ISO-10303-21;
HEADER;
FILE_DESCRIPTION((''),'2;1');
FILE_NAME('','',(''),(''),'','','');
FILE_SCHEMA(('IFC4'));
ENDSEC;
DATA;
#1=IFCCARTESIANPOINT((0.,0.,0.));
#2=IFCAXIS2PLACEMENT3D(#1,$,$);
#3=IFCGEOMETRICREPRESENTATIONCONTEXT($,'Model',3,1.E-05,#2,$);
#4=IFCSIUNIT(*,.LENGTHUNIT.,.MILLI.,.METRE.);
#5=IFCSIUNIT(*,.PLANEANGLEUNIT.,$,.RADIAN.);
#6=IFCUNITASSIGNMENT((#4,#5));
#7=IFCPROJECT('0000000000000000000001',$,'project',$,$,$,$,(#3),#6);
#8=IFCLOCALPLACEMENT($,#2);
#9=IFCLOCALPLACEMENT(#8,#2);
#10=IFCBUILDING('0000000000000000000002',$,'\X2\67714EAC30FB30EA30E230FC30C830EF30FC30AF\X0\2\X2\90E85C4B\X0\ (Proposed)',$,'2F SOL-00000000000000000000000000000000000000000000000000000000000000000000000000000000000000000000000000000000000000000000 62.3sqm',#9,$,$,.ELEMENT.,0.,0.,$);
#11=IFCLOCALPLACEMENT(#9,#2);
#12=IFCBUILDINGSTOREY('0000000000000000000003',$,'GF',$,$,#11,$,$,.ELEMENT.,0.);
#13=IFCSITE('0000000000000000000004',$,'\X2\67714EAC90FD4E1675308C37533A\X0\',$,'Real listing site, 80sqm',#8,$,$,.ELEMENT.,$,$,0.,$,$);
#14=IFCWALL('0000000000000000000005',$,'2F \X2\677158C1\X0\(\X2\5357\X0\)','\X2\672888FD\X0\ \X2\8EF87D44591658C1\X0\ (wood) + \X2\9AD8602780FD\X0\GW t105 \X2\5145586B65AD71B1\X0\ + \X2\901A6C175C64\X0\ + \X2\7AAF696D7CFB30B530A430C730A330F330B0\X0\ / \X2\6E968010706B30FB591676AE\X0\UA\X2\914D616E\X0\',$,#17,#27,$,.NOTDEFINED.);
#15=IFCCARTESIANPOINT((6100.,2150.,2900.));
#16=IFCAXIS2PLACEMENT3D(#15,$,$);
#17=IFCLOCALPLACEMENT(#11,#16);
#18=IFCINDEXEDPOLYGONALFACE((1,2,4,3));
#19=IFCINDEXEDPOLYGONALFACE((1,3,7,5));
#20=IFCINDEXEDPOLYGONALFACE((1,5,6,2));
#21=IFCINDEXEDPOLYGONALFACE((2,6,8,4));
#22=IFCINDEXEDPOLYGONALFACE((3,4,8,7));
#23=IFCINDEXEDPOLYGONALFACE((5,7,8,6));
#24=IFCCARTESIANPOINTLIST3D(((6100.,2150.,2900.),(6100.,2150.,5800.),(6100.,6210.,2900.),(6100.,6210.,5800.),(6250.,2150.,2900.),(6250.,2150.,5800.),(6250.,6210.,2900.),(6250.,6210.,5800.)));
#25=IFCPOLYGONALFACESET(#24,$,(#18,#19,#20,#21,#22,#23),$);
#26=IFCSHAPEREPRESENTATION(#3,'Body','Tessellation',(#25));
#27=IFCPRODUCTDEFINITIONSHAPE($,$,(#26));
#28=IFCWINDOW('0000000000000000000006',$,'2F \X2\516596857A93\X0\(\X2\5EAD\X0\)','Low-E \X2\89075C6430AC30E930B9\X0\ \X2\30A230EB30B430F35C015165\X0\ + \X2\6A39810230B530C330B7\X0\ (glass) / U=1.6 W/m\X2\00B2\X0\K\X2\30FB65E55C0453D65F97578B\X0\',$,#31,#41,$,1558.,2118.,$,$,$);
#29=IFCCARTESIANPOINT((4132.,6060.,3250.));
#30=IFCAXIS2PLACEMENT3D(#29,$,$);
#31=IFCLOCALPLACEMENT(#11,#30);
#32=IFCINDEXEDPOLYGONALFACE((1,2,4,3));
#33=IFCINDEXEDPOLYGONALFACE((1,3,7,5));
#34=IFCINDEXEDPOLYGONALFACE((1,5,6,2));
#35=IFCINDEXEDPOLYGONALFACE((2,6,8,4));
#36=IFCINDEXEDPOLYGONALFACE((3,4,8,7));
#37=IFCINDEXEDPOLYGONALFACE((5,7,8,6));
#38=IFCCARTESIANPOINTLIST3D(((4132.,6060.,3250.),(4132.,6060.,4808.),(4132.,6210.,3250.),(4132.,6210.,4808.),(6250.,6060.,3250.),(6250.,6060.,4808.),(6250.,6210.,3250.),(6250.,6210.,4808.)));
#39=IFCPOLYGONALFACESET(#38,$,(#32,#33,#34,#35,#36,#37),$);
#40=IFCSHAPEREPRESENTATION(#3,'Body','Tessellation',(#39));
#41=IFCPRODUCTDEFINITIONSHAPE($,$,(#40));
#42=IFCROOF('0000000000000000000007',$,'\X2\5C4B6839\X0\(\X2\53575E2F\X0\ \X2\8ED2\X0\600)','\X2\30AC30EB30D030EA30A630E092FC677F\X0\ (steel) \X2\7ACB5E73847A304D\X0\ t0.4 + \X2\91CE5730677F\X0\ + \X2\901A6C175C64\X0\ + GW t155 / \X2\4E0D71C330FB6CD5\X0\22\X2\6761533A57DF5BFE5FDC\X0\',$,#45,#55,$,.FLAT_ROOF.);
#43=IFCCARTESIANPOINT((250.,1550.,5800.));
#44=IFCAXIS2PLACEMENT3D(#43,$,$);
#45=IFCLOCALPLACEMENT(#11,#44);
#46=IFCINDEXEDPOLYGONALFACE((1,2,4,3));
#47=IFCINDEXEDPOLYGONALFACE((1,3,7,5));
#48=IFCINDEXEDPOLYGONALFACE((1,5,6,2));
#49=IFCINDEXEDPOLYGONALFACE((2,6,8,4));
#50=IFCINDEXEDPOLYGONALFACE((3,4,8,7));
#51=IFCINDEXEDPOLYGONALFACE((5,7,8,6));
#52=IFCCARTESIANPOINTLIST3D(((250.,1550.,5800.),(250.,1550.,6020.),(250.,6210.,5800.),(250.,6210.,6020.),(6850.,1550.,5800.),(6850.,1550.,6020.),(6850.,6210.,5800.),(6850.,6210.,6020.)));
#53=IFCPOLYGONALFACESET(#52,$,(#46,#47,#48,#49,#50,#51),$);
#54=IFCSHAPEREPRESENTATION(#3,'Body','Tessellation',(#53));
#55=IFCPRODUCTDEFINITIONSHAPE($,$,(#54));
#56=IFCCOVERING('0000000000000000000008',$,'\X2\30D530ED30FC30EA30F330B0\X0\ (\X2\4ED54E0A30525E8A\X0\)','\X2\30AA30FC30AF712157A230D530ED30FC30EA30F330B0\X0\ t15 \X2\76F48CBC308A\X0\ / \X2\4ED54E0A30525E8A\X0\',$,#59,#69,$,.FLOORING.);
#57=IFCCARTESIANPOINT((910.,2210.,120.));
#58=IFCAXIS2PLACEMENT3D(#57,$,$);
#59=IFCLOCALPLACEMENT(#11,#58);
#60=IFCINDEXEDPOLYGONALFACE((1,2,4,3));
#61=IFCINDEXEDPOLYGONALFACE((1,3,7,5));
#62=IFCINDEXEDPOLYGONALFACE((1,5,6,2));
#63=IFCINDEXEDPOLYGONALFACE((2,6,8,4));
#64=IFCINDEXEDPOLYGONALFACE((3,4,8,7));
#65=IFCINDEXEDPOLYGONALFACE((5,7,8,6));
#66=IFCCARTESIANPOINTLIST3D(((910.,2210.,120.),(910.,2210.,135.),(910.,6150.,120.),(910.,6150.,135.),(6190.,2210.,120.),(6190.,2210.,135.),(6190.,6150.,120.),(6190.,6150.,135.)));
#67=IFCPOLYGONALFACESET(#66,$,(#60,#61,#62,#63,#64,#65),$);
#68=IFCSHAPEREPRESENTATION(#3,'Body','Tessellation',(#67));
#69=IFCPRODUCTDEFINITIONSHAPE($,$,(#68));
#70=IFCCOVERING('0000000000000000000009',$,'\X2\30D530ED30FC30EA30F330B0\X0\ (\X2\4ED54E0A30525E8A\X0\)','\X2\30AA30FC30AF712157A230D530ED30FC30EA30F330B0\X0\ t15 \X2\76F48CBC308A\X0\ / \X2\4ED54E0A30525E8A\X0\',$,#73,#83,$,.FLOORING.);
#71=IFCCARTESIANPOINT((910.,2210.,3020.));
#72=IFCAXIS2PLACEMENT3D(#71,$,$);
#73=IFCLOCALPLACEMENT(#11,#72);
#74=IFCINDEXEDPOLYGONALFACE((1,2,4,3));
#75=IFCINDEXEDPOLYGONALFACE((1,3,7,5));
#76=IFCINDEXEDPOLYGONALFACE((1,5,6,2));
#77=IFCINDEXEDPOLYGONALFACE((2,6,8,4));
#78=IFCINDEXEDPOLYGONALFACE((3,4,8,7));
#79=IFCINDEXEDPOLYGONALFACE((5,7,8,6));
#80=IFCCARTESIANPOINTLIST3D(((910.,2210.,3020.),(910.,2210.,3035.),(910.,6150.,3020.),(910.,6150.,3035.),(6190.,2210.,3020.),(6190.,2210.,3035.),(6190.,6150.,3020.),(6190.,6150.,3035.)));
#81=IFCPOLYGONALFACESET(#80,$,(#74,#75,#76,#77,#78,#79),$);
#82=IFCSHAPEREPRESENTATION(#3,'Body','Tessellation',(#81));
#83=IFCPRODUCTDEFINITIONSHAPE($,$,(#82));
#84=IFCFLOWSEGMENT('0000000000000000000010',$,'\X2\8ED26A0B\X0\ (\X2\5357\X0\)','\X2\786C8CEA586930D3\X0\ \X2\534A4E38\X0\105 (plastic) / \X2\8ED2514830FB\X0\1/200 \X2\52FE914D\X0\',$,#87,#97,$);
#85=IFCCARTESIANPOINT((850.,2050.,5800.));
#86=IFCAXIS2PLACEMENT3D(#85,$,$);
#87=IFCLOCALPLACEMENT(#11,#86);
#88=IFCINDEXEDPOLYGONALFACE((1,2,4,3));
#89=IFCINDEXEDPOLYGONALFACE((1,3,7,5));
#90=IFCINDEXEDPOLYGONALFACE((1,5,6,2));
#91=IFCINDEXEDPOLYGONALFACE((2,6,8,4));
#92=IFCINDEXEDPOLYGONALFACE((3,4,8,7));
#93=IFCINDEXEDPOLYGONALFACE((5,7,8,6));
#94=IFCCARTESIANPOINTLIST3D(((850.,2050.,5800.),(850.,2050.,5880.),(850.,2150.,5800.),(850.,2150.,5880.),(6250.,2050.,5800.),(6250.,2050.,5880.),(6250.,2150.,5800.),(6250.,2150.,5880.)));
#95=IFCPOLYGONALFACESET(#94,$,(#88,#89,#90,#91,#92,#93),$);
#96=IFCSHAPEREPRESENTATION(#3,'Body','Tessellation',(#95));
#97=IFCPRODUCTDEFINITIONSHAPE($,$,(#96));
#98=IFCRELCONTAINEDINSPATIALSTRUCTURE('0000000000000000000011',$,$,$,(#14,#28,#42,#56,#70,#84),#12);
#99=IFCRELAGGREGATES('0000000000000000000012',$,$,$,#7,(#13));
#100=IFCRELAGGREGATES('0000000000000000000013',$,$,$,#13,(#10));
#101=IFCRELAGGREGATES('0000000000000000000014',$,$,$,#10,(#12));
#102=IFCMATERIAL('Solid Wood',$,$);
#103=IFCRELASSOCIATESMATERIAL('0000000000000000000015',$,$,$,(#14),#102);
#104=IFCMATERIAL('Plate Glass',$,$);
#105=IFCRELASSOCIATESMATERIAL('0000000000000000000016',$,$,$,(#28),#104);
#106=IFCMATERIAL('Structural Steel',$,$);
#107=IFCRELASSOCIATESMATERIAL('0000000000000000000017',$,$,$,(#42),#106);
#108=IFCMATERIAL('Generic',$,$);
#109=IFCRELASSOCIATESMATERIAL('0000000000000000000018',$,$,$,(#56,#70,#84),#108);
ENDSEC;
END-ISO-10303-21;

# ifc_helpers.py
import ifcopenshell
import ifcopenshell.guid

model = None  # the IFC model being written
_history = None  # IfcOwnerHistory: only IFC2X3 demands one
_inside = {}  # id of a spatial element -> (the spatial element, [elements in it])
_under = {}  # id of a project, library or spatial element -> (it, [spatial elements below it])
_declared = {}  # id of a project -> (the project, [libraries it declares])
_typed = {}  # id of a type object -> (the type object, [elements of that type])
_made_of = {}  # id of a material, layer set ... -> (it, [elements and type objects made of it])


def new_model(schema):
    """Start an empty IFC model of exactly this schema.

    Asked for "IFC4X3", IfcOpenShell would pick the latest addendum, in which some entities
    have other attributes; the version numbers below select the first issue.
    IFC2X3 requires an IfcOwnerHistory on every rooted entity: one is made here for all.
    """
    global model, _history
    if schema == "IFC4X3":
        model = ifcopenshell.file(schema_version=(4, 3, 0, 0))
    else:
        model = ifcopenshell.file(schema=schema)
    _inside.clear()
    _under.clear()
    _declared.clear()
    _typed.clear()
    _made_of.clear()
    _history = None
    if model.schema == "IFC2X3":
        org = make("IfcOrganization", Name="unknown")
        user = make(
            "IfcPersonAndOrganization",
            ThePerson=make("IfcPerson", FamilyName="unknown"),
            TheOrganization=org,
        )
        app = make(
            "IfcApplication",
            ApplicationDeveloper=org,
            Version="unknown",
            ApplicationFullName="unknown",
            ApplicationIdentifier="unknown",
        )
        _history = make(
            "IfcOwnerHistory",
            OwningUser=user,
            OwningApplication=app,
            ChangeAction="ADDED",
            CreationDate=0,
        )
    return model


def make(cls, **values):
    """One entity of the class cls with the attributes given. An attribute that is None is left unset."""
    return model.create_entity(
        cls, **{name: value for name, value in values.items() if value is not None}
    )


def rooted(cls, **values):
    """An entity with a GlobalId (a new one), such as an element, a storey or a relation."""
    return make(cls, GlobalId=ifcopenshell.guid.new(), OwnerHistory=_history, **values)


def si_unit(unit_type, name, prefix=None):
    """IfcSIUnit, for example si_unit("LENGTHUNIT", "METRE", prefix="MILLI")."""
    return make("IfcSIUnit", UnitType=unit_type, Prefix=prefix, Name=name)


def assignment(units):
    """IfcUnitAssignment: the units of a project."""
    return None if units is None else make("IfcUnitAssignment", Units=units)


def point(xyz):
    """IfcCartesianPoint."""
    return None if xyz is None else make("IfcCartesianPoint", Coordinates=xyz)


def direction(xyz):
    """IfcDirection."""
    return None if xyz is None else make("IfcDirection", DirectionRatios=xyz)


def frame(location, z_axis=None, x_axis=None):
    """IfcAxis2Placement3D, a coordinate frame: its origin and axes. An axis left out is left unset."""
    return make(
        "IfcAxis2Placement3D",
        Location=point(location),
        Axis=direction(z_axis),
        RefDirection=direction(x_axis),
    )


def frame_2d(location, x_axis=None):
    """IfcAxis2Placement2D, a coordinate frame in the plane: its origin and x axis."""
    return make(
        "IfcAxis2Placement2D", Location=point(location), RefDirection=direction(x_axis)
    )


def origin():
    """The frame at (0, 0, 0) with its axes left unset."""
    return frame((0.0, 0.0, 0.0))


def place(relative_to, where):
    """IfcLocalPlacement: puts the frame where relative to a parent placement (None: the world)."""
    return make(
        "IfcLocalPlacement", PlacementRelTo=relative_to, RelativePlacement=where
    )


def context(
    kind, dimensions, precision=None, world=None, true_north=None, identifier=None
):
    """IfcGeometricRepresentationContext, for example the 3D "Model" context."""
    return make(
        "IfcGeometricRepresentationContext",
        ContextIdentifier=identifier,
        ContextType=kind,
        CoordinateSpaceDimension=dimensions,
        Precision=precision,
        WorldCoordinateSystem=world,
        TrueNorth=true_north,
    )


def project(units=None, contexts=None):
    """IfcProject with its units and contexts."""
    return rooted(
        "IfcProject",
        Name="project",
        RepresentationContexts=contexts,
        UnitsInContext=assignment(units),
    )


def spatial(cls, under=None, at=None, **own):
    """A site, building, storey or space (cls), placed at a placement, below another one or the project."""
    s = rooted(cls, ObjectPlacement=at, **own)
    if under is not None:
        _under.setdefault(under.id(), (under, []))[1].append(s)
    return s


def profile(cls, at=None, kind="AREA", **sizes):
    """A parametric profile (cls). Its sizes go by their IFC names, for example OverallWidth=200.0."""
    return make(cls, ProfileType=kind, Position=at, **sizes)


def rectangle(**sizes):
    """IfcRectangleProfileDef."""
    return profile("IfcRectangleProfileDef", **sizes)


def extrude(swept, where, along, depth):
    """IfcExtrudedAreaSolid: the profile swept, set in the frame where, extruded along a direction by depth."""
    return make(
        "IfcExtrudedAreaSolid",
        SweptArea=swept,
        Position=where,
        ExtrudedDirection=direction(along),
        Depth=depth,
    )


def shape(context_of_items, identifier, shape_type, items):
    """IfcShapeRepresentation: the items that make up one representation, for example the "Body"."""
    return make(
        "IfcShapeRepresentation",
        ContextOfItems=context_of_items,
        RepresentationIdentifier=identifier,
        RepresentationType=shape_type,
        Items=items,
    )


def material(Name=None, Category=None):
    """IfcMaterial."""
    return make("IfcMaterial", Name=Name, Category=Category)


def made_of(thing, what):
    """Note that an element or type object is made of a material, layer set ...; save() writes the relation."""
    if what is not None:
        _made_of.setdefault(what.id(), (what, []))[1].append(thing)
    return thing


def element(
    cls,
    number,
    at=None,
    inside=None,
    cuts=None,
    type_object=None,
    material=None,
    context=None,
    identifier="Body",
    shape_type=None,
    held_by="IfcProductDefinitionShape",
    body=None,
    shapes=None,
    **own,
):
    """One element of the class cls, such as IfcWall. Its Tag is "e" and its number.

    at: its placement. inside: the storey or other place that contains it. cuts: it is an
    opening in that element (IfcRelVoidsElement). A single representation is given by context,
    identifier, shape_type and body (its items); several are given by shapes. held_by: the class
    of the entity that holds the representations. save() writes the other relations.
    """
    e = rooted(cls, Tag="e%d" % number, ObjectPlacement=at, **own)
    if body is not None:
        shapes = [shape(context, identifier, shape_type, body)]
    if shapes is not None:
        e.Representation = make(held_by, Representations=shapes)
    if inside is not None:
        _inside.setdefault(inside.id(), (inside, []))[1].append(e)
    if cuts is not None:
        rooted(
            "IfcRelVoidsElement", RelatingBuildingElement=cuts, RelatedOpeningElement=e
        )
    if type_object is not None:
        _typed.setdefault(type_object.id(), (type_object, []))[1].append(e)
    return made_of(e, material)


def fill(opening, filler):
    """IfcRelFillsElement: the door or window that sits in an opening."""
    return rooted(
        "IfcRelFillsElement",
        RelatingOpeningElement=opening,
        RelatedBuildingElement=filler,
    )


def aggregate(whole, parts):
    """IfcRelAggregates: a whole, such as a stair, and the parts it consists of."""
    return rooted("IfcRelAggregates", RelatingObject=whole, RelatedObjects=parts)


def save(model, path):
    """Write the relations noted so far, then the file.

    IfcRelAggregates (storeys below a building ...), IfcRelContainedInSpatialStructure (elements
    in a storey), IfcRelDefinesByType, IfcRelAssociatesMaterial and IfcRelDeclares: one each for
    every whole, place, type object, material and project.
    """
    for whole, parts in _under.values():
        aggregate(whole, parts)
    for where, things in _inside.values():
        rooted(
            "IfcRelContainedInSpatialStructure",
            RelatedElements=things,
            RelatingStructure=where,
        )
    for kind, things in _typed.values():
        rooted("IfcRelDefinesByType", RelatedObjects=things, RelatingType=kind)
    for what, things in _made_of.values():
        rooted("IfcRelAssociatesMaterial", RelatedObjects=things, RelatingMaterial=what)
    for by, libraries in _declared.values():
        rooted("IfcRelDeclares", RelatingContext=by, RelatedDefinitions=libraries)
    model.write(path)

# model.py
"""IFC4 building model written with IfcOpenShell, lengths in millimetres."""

from ifc_helpers import new_model, si_unit, frame, frame_2d, origin, place, context, project, spatial, rectangle, extrude, material, element, fill, save


model = new_model("IFC4")

# Units and contexts
model_context = context("Model", 3, precision=1e-05, world=origin())
ifc_project = project(units=[si_unit("LENGTHUNIT", "METRE", prefix="MILLI"), si_unit("PLANEANGLEUNIT", "RADIAN")], contexts=[model_context])

# Site, building, storey
site_placement = place(None, origin())
site = spatial("IfcSite", under=ifc_project, at=site_placement, Name="東京都世田谷区", ObjectType="Real listing site, 80sqm", CompositionType="ELEMENT", RefElevation=0.0)
building_placement = place(site_placement, origin())
building = spatial("IfcBuilding", under=site, at=building_placement, Name="東京・リモートワーク2部屋 (Proposed)", ObjectType="2F SOL-00000000000000000000000000000000000000000000000000000000000000000000000000000000000000000000000000000000000000000000 62.3sqm", CompositionType="ELEMENT", ElevationOfRefHeight=0.0, ElevationOfTerrain=0.0)
storey_placement = place(building_placement, origin())
storey = spatial("IfcBuildingStorey", under=building, at=storey_placement, Name="GF", CompositionType="ELEMENT", Elevation=0.0)

# Shared definitions
ifc_material_1 = material(Name="Solid Wood")

# Wall, opening, window
ifc_material_2 = material(Name="Plate Glass")
wall_1_placement = place(storey_placement, frame((6100.0, 2150.0, 2900.0)))
wall_1 = element("IfcWall", 1, at=wall_1_placement, inside=storey, material=ifc_material_1, Name="2F 東壁(南)", Description="木製 軸組外壁 (wood) + 高性能GW t105 充填断熱 + 通気層 + 窯業系サイディング / 準耐火・外皮UA配慮", PredefinedType="NOTDEFINED", context=model_context, shape_type="SweptSolid", body=[
    extrude(rectangle(XDim=150.0, YDim=4060.0, at=frame_2d((75.0, 2030.0))), frame((6100.0, 2150.0, 2900.0)), (0.0, 0.0, 1.0), 2900.0),
])
opening_1_placement = place(storey_placement, frame((4132.0, 6060.0, 3250.0)))
opening_1 = element("IfcOpeningElement", 2, at=opening_1_placement, cuts=wall_1, PredefinedType="NOTDEFINED", context=model_context, shape_type="SweptSolid", body=[
    extrude(rectangle(XDim=2118.0, YDim=150.0, at=frame_2d((1059.0, 75.0))), frame((4132.0, 6060.0, 3250.0)), (0.0, 0.0, 1.0), 1558.0),
])
window_1_placement = place(storey_placement, frame((4132.0, 6060.0, 3250.0)))
window_1 = element("IfcWindow", 3, at=window_1_placement, inside=storey, material=ifc_material_2, Name="2F 入隅窓(庭)", Description="Low-E 複層ガラス アルゴン封入 + 樹脂サッシ (glass) / U=1.6 W/m²K・日射取得型", OverallHeight=1558.0, OverallWidth=2118.0, context=model_context, shape_type="SweptSolid", body=[
    extrude(rectangle(XDim=2118.0, YDim=150.0, at=frame_2d((1059.0, 75.0))), frame((4132.0, 6060.0, 3250.0)), (0.0, 0.0, 1.0), 1558.0),
])
fill(opening_1, window_1)

# Roof
ifc_material_3 = material(Name="Structural Steel")
for number, where, name in (
    (4, (250.0, 1550.0, 5800.0), "屋根(南帯 軒600)"),
):
    element("IfcRoof", number, at=place(storey_placement, frame(where)), inside=storey, material=ifc_material_3, Name=name, Description="ガルバリウム鋼板 (steel) 立平葺き t0.4 + 野地板 + 通気層 + GW t155 / 不燃・法22条区域対応", PredefinedType="FLAT_ROOF", context=model_context, shape_type="SweptSolid", body=[
        extrude(rectangle(XDim=6600.0, YDim=4660.0, at=frame_2d((3300.0, 2330.0))), frame((250.0, 1550.0, 5800.0)), (0.0, 0.0, 1.0), 220.0),
    ])

# Coverings
ifc_material_4 = material(Name="Generic")
covering_1_placement = place(storey_placement, frame((910.0, 2210.0, 120.0)))
element("IfcCovering", 5, at=covering_1_placement, inside=storey, material=ifc_material_4, Name="フローリング (仕上げ床)", Description="オーク無垢フローリング t15 直貼り / 仕上げ床", PredefinedType="FLOORING", context=model_context, shape_type="SweptSolid", body=[
    extrude(rectangle(XDim=5280.0, YDim=3940.0, at=frame_2d((2640.0, 1970.0))), frame((910.0, 2210.0, 120.0)), (0.0, 0.0, 1.0), 15.0),
])
covering_2_placement = place(storey_placement, frame((910.0, 2210.0, 3020.0)))
element("IfcCovering", 6, at=covering_2_placement, inside=storey, material=ifc_material_4, Name="フローリング (仕上げ床)", Description="オーク無垢フローリング t15 直貼り / 仕上げ床", PredefinedType="FLOORING", context=model_context, shape_type="SweptSolid", body=[
    extrude(rectangle(XDim=5280.0, YDim=3940.0, at=frame_2d((2640.0, 1970.0))), frame((910.0, 2210.0, 3020.0)), (0.0, 0.0, 1.0), 15.0),
])

# Flow segment
flow_segment_placement = place(storey_placement, frame((850.0, 2050.0, 5800.0)))
element("IfcFlowSegment", 7, at=flow_segment_placement, inside=storey, material=ifc_material_4, Name="軒樋 (南)", Description="硬質塩ビ 半丸105 (plastic) / 軒先・1/200 勾配", context=model_context, shape_type="SweptSolid", body=[
    extrude(rectangle(XDim=5400.0, YDim=100.0, at=frame_2d((2700.0, 50.0))), frame((850.0, 2050.0, 5800.0)), (0.0, 0.0, 1.0), 80.0),
])

save(model, "model.ifc")
